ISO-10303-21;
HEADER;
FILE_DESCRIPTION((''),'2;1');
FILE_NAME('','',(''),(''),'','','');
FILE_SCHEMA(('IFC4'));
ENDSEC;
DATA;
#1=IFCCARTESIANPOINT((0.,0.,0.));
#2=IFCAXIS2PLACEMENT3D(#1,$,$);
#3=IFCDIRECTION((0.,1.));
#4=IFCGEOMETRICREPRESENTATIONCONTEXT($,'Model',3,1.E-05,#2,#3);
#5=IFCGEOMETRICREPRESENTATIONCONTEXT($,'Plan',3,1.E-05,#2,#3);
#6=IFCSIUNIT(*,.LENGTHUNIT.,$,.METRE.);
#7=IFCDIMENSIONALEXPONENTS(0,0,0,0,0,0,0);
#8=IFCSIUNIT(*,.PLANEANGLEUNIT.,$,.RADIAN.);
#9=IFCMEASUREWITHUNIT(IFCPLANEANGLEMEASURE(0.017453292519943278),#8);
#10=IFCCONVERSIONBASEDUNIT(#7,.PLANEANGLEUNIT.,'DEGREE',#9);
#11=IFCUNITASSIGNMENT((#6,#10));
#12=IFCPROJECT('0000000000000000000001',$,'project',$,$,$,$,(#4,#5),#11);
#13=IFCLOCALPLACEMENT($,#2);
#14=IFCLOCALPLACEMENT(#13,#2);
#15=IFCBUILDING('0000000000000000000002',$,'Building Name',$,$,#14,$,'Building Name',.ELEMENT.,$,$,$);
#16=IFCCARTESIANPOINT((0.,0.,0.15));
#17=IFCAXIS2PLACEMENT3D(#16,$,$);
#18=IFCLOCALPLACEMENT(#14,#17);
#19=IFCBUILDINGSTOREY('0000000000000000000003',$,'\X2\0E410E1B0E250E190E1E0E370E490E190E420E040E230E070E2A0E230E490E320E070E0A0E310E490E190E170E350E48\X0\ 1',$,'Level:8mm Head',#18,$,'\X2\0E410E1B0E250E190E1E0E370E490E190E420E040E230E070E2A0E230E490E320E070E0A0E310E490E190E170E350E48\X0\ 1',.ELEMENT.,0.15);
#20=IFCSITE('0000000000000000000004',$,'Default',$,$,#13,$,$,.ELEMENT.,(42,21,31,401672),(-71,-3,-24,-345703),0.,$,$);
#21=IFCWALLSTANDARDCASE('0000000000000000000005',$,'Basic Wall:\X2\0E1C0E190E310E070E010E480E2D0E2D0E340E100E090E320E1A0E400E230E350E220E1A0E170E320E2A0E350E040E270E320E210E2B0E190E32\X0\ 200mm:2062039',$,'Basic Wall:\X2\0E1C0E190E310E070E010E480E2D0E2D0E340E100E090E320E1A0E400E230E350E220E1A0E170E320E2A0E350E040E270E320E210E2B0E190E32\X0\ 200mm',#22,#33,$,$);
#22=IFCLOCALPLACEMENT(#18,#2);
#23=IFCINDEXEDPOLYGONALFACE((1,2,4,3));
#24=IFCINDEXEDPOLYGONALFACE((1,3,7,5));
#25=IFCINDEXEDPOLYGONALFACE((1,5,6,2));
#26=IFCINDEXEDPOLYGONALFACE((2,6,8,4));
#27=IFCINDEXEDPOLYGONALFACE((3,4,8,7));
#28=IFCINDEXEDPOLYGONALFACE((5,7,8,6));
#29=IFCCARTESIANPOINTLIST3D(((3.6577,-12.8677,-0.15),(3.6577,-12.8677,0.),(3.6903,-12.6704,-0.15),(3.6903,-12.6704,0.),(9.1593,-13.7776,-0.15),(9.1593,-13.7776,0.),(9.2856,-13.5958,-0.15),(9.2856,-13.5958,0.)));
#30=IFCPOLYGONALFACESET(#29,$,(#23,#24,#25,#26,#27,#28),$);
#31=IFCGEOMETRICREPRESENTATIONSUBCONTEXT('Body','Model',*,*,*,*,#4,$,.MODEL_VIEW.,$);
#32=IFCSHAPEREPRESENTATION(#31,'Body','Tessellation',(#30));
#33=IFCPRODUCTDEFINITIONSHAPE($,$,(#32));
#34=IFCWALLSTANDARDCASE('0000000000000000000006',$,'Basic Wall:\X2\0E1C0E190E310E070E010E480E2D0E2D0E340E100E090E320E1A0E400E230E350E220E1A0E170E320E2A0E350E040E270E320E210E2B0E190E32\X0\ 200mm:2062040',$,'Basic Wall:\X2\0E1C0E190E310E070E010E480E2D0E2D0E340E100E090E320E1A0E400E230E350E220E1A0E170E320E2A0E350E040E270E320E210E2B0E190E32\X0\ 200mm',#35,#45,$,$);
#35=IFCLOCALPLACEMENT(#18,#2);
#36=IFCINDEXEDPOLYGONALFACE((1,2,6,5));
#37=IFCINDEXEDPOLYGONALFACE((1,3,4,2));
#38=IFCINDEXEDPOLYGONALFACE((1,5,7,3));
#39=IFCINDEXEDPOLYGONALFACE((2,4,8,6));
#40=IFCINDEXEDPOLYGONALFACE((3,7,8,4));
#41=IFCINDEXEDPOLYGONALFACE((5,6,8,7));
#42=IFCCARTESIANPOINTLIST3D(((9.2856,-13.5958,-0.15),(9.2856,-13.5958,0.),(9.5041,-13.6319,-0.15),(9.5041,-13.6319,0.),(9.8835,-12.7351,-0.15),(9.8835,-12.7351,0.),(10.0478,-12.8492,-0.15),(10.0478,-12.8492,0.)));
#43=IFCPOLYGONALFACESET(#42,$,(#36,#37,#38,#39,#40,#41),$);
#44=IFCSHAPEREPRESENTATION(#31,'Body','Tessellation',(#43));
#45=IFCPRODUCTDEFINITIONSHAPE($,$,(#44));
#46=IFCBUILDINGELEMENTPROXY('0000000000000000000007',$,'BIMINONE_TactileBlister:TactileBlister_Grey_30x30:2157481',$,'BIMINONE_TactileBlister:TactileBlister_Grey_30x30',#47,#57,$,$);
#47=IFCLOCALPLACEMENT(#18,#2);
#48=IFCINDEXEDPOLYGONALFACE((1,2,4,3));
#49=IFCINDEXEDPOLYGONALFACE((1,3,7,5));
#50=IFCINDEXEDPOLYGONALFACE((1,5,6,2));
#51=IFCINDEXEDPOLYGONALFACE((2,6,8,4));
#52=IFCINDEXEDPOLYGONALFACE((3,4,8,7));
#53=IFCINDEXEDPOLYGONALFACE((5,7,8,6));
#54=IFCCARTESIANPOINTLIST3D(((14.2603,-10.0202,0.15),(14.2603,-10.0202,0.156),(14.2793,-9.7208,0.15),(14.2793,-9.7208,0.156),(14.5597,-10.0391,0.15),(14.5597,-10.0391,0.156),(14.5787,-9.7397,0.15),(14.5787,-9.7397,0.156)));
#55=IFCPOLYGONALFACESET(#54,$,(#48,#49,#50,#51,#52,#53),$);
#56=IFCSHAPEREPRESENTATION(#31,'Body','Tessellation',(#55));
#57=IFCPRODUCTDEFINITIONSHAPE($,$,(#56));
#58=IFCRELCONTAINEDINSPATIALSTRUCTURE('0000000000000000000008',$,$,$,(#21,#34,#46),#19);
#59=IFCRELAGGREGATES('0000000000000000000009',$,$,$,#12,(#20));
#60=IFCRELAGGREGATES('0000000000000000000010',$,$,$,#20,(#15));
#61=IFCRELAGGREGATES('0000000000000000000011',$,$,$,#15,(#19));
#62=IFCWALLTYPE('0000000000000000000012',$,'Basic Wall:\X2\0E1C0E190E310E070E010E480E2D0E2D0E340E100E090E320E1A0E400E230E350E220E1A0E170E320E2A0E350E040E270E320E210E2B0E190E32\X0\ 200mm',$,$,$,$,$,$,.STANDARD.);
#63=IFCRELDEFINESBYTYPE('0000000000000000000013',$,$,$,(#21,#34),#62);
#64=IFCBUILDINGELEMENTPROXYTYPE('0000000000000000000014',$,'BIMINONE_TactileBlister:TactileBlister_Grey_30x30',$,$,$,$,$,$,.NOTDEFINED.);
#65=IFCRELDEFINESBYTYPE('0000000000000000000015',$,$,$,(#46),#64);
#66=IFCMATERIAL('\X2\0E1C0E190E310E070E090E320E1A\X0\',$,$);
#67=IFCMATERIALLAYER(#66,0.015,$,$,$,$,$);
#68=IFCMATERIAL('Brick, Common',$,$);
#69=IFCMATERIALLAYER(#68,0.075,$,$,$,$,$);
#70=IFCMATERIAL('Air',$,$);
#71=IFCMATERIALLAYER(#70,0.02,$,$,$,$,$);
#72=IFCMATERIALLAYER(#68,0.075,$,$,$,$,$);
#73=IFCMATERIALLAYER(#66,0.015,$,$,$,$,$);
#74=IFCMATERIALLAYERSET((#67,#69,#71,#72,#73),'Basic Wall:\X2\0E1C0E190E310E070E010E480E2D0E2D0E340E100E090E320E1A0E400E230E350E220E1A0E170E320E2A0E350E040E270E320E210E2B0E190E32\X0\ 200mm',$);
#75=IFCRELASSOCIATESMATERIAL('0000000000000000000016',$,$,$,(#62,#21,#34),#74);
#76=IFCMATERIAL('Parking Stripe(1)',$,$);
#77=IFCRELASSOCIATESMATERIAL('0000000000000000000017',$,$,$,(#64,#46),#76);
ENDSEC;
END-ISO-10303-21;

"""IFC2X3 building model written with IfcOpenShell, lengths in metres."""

from ifc_helpers import new_model, entity, si_unit, converted_unit, direction, frame, origin, origin_2d_with_axis, place, context, subcontext, project, spatial, polyline, rectangle, outline, extrude, source, transform, mapped, material, layer, layer_set, layer_usage, type_object, type_shapes, element, save


model = new_model("IFC2X3")

# Units and contexts
model_context = context("Model", 3, precision=1e-05, world=origin(), true_north=direction((0.0, 1.0)))
plan_context = context("Plan", 3, precision=1e-05, world=origin(), true_north=direction((0.0, 1.0)))
body_context = subcontext(model_context, "Body", "Model", "MODEL_VIEW")
ifc_project = project(units=[si_unit("LENGTHUNIT", "METRE"), converted_unit("PLANEANGLEUNIT", "DEGREE", entity("IfcPlaneAngleMeasure", 0.017453292519943278), si_unit("PLANEANGLEUNIT", "RADIAN"), dimensions=[0, 0, 0, 0, 0, 0, 0])], contexts=[model_context, plan_context])

# Site, building, storey
site_placement = place(None, origin())
site = spatial("IfcSite", under=ifc_project, at=site_placement, Name="Default", CompositionType="ELEMENT", RefLatitude=(42, 21, 31, 401672), RefLongitude=(-71, -3, -24, -345703), RefElevation=0.0)
building_placement = place(site_placement, origin())
building = spatial("IfcBuilding", under=site, at=building_placement, Name="Building Name", LongName="Building Name", CompositionType="ELEMENT")
storey_placement = place(building_placement, frame((0.0, 0.0, 0.15)))
storey = spatial("IfcBuildingStorey", under=building, at=storey_placement, Name="แปลนพื้นโครงสร้างชั้นที่ 1", ObjectType="Level:8mm Head", LongName="แปลนพื้นโครงสร้างชั้นที่ 1", CompositionType="ELEMENT", Elevation=0.15)

# Walls
ifc_material_1 = material(Name="ผนังฉาบ")
ifc_material_2 = material(Name="Brick, Common")
ifc_layer_1 = layer(ifc_material_1, 0.015)
ifc_layer_2 = layer(ifc_material_2, 0.075)
ifc_material_3 = material(Name="Air")
ifc_layer_3 = layer(ifc_material_3, 0.02)
ifc_layer_4 = layer(ifc_material_2, 0.075)
ifc_layer_5 = layer(ifc_material_1, 0.015)
ifc_layer_set_1 = layer_set([ifc_layer_1, ifc_layer_2, ifc_layer_3, ifc_layer_4, ifc_layer_5], Name="Basic Wall:ผนังก่ออิฐฉาบเรียบทาสีความหนา 200mm")
wall_type_1 = type_object("IfcWallType", Name="Basic Wall:ผนังก่ออิฐฉาบเรียบทาสีความหนา 200mm", PredefinedType="STANDARD", material=ifc_layer_set_1)
ifc_layer_usage_1 = layer_usage(ifc_layer_set_1, "AXIS2", "NEGATIVE", 0.1)
wall_1_placement = place(storey_placement, frame((9.2693, -13.6944, -0.15), z_axis=(0.0, 0.0, 1.0), x_axis=(-0.986599, 0.163166, 0.0)))
element("IfcWallStandardCase", 1, at=wall_1_placement, inside=storey, type_object=wall_type_1, material=ifc_layer_usage_1, Name="Basic Wall:ผนังก่ออิฐฉาบเรียบทาสีความหนา 200mm:2062039", ObjectType="Basic Wall:ผนังก่ออิฐฉาบเรียบทาสีความหนา 200mm", context=body_context, shape_type="SweptSolid", body=[
    extrude(outline(polyline([(5.6713, -0.1), (5.6713, 0.1), (0.0949, 0.1), (0.0, -0.1), (5.6713, -0.1)])), origin(), (0.0, 0.0, 1.0), 0.15),
])
ifc_layer_usage_2 = layer_usage(ifc_layer_set_1, "AXIS2", "NEGATIVE", 0.1)
wall_2_placement = place(storey_placement, frame((9.9656, -12.7922, -0.15), z_axis=(0.0, 0.0, 1.0), x_axis=(-0.570524, -0.821281, 0.0)))
element("IfcWallStandardCase", 2, at=wall_2_placement, inside=storey, type_object=wall_type_1, material=ifc_layer_usage_2, Name="Basic Wall:ผนังก่ออิฐฉาบเรียบทาสีความหนา 200mm:2062040", ObjectType="Basic Wall:ผนังก่ออิฐฉาบเรียบทาสีความหนา 200mm", context=body_context, shape_type="SweptSolid", body=[
    extrude(outline(polyline([(1.048, -0.1), (0.953, 0.1), (0.0, 0.1), (0.0, -0.1), (1.048, -0.1)])), origin(), (0.0, 0.0, 1.0), 0.15),
])

# Building element proxy
ifc_material_4 = material(Name="Parking Stripe(1)")
building_element_proxy_type = type_object("IfcBuildingElementProxyType", Name="BIMINONE_TactileBlister:TactileBlister_Grey_30x30", PredefinedType="NOTDEFINED", material=ifc_material_4)
shared_shape = source(origin(), body_context, "Body", "SweptSolid", [
    extrude(rectangle(XDim=0.3, YDim=0.3, at=origin_2d_with_axis()), frame((0.15, -0.15, 0.0), z_axis=(0.0, 0.0, 1.0), x_axis=(-1.0, 0.0, 0.0)), (0.0, 0.0, 1.0), 0.006),
])
type_shapes(building_element_proxy_type, [shared_shape])
proxy_placement = place(storey_placement, frame((14.2603, -10.0202, 0.15), z_axis=(0.0, 0.0, 1.0), x_axis=(0.063097, 0.998007, 0.0)))
element("IfcBuildingElementProxy", 3, at=proxy_placement, inside=storey, type_object=building_element_proxy_type, material=ifc_material_4, Name="BIMINONE_TactileBlister:TactileBlister_Grey_30x30:2157481", ObjectType="BIMINONE_TactileBlister:TactileBlister_Grey_30x30", context=body_context, shape_type="MappedRepresentation", body=[
    mapped(shared_shape, transform((0.0, 0.0, 0.0), scale=1.0)),
])

save(model, "model.ifc")
